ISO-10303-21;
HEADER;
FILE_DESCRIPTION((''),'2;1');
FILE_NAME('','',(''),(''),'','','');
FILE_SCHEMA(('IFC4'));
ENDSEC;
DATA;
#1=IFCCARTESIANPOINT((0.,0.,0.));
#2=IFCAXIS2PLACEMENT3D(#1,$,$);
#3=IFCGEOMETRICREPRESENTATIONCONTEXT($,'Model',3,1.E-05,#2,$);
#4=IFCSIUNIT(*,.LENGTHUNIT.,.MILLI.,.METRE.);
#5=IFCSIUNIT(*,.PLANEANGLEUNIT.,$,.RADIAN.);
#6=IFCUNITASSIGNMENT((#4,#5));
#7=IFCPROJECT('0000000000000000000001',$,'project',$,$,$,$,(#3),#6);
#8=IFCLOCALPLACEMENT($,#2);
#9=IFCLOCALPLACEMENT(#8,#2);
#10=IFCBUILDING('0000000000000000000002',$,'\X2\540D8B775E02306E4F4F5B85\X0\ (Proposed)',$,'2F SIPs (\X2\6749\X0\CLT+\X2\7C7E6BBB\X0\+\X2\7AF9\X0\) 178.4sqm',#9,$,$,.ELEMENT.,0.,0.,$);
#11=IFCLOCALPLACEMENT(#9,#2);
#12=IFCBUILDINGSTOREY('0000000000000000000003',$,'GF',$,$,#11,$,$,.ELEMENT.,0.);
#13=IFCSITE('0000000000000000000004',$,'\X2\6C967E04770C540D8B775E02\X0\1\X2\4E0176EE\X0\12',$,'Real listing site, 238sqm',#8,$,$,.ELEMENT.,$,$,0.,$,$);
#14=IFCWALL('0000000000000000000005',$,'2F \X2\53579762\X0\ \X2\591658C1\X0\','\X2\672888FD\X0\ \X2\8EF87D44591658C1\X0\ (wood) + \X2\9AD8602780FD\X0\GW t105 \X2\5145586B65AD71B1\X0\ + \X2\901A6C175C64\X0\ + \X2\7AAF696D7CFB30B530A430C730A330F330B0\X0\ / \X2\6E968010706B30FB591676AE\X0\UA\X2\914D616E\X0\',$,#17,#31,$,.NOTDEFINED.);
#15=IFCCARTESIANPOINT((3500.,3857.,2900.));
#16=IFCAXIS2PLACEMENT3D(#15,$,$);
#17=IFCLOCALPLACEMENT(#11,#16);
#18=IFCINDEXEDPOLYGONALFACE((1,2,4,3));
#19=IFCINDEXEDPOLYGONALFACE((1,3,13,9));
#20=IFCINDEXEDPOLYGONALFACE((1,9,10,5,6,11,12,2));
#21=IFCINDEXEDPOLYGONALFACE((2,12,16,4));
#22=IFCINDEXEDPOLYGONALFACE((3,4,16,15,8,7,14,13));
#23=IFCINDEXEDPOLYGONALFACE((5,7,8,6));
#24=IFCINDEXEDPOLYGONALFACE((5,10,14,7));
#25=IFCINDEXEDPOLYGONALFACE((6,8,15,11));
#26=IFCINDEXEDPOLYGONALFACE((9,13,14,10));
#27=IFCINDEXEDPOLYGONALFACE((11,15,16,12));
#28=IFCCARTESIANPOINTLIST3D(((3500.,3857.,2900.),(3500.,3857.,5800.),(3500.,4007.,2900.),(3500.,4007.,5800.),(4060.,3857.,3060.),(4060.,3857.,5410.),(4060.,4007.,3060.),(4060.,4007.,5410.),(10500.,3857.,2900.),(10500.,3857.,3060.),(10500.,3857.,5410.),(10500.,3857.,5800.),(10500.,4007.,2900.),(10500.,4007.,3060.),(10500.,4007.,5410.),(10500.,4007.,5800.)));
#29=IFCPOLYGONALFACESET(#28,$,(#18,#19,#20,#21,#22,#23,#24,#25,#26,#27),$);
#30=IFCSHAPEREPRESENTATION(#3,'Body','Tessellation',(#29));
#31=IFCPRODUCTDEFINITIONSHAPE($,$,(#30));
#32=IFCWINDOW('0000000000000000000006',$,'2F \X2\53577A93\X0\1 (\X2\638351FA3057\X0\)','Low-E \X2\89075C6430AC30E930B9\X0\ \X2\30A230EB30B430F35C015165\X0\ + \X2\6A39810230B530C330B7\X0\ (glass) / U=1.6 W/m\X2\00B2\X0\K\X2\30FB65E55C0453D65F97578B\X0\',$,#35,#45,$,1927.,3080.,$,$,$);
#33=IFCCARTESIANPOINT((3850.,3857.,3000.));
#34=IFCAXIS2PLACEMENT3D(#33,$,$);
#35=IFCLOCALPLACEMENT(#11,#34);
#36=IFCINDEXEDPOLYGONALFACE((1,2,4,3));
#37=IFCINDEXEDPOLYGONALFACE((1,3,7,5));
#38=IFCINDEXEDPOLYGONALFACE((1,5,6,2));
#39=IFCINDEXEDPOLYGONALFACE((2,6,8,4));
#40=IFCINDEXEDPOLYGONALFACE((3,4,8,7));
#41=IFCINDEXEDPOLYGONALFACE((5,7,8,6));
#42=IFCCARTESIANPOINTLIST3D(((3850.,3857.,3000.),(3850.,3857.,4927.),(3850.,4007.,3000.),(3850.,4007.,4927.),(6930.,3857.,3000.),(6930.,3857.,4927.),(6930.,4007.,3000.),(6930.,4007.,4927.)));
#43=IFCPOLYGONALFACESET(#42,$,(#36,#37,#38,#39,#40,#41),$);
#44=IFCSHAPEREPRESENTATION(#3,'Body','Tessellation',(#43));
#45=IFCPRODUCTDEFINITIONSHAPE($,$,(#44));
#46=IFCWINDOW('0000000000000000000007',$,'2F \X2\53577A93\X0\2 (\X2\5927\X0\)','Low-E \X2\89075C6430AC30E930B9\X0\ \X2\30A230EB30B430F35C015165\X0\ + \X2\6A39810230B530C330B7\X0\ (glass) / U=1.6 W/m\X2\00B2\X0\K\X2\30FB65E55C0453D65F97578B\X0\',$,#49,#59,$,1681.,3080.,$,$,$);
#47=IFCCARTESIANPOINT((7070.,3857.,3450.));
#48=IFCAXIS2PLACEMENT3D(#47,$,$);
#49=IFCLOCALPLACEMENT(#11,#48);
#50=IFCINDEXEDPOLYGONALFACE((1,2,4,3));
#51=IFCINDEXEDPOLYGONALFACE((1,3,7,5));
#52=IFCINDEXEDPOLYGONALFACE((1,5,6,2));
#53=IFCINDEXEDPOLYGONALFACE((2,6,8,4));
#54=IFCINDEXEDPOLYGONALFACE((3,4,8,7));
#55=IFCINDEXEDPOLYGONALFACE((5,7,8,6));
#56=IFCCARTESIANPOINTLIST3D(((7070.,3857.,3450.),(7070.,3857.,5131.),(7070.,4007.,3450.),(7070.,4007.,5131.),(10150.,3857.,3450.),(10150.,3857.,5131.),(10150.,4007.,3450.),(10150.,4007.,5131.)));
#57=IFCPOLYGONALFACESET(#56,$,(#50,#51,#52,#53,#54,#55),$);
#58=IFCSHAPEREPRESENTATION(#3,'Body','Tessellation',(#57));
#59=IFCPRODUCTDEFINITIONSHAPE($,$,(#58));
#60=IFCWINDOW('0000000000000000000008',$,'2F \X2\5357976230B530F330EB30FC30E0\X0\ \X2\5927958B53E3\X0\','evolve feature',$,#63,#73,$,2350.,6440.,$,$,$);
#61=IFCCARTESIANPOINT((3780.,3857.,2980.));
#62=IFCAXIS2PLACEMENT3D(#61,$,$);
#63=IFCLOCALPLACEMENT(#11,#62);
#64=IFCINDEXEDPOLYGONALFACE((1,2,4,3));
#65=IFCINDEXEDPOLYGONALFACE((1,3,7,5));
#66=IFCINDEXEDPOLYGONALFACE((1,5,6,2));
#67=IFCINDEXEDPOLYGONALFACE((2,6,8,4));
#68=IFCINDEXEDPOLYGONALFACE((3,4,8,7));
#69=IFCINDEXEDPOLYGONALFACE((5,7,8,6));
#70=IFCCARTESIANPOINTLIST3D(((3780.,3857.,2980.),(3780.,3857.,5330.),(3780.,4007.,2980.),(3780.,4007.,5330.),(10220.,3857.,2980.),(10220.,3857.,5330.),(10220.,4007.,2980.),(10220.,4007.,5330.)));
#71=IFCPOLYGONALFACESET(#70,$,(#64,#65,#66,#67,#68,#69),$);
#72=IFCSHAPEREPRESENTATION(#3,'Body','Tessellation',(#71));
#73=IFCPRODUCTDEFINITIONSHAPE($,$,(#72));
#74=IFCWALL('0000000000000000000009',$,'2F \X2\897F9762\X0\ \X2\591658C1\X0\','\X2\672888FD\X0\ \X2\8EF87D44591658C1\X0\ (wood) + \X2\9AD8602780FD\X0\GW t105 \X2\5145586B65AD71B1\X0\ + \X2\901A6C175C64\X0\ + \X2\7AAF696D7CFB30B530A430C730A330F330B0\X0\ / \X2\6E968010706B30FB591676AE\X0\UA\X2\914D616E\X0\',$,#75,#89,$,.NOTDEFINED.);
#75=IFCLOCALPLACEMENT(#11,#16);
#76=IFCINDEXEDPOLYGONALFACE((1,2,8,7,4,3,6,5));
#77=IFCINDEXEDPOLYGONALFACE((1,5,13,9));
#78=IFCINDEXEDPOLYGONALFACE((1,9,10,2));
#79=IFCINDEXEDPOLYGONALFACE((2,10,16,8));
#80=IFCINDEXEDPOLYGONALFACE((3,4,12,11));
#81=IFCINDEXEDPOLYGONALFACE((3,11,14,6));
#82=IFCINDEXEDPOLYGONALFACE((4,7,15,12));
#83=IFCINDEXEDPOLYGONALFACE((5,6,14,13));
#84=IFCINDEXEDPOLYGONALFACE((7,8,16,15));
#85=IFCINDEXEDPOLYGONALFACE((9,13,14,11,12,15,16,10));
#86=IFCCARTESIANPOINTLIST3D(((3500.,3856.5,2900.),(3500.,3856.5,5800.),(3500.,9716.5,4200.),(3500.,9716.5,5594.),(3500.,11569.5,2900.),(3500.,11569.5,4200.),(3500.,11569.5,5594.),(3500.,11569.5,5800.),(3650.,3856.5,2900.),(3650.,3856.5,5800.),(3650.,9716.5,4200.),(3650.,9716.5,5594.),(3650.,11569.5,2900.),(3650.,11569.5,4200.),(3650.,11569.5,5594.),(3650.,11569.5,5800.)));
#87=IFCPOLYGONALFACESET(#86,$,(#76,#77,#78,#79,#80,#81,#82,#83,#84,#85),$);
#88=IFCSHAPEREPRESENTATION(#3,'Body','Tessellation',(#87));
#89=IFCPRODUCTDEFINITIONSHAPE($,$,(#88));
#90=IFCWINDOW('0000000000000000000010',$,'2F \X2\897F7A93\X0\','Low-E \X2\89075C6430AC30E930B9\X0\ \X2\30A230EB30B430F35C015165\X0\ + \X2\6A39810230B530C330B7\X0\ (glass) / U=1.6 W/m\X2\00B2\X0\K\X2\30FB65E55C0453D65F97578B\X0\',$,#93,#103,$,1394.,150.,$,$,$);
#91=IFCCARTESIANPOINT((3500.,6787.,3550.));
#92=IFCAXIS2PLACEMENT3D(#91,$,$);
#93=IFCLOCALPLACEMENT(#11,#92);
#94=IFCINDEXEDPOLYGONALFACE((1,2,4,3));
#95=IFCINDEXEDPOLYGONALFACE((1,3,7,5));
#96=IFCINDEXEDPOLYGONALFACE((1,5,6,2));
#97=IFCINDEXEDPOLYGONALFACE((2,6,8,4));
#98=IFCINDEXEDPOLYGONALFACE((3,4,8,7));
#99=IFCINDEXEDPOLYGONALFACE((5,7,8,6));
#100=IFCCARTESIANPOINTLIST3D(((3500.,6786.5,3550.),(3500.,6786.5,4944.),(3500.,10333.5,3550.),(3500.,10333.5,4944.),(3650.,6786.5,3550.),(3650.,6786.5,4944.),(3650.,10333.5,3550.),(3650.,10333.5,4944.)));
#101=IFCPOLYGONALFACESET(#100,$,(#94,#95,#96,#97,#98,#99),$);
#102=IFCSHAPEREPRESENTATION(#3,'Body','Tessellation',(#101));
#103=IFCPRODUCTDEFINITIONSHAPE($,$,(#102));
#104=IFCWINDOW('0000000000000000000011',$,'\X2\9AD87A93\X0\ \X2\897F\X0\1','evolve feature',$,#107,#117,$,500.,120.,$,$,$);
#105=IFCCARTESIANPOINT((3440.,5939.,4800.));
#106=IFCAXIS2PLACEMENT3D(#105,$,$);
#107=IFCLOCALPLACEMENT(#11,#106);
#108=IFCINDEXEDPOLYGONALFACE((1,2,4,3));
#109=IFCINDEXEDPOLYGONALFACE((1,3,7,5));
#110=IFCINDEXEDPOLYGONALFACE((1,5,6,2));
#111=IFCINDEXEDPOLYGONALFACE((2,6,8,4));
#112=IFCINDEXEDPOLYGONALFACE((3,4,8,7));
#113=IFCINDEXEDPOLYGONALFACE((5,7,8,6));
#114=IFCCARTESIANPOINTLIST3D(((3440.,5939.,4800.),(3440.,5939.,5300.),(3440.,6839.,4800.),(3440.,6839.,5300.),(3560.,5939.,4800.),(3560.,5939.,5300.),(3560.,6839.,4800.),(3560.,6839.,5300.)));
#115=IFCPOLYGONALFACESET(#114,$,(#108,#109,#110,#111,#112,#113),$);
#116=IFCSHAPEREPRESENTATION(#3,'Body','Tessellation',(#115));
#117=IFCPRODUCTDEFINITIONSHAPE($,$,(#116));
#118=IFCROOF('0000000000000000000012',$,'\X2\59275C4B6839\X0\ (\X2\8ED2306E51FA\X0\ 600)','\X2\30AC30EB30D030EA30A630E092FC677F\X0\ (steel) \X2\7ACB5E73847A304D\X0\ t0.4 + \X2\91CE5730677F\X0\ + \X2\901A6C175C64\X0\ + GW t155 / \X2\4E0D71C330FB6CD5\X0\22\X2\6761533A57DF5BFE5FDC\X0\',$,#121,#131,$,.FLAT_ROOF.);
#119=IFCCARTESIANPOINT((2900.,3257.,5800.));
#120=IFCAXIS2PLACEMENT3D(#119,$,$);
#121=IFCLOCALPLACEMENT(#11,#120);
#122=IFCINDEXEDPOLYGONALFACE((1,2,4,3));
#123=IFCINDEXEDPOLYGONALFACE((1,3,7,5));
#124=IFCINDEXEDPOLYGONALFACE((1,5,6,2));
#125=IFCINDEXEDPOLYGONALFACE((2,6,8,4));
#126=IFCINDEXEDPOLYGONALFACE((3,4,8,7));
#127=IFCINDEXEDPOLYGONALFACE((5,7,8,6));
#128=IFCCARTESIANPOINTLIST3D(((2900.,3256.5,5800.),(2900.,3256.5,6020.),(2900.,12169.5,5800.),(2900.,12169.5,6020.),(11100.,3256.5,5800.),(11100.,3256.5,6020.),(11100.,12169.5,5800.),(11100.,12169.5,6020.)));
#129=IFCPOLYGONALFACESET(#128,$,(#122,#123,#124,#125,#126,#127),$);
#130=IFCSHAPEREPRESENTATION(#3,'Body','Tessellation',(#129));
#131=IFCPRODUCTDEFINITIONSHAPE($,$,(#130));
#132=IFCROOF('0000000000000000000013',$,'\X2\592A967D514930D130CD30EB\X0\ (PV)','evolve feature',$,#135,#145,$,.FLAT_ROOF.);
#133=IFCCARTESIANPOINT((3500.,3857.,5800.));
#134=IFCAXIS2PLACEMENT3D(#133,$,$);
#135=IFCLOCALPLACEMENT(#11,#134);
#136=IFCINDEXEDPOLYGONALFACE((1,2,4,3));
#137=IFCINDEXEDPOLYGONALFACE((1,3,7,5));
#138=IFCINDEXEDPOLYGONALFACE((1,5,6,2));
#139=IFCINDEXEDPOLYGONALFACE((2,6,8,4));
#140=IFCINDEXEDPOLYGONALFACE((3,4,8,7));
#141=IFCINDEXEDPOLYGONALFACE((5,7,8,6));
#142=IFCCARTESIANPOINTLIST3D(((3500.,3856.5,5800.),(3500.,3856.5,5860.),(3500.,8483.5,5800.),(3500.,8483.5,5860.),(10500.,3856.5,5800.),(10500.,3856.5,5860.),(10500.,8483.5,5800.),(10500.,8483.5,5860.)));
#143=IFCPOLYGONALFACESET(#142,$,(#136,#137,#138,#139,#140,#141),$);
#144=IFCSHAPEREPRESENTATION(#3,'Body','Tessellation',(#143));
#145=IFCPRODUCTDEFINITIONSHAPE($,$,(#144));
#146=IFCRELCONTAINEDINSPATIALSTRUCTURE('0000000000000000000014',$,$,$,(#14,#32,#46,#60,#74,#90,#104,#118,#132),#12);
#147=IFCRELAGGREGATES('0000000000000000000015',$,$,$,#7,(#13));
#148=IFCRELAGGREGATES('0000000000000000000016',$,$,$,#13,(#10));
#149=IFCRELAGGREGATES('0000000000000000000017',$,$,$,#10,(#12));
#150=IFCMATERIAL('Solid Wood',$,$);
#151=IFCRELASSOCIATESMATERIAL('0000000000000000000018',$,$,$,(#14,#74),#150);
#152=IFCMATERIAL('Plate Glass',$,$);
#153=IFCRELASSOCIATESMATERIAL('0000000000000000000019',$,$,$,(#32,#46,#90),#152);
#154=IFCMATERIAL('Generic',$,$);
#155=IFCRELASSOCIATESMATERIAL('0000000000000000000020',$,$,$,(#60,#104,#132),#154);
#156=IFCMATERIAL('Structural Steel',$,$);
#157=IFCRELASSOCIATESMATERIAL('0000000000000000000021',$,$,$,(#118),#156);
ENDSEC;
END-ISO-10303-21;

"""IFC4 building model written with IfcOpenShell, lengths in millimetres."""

from ifc_helpers import new_model, si_unit, frame, frame_2d, origin, place, context, project, spatial, rectangle, extrude, material, element, fill, save


model = new_model("IFC4")

# Units and contexts
model_context = context("Model", 3, precision=1e-05, world=origin())
ifc_project = project(units=[si_unit("LENGTHUNIT", "METRE", prefix="MILLI"), si_unit("PLANEANGLEUNIT", "RADIAN")], contexts=[model_context])

# Site, building, storey
site_placement = place(None, origin())
site = spatial("IfcSite", under=ifc_project, at=site_placement, Name="沖縄県名護市1丁目12", ObjectType="Real listing site, 238sqm", CompositionType="ELEMENT", RefElevation=0.0)
building_placement = place(site_placement, origin())
building = spatial("IfcBuilding", under=site, at=building_placement, Name="名護市の住宅 (Proposed)", ObjectType="2F SIPs (杉CLT+籾殻+竹) 178.4sqm", CompositionType="ELEMENT", ElevationOfRefHeight=0.0, ElevationOfTerrain=0.0)
storey_placement = place(building_placement, origin())
storey = spatial("IfcBuildingStorey", under=building, at=storey_placement, Name="GF", CompositionType="ELEMENT", Elevation=0.0)

# Shared definitions
ifc_material_1 = material(Name="Solid Wood")
ifc_material_2 = material(Name="Generic")

# Shared definitions
ifc_material_3 = material(Name="Plate Glass")

# Walls, openings, windows
wall_1_placement = place(storey_placement, frame((3500.0, 3857.0, 2900.0)))
wall_1 = element("IfcWall", 1, at=wall_1_placement, inside=storey, material=ifc_material_1, Name="2F 南面 外壁", Description="木製 軸組外壁 (wood) + 高性能GW t105 充填断熱 + 通気層 + 窯業系サイディング / 準耐火・外皮UA配慮", PredefinedType="NOTDEFINED", context=model_context, shape_type="SweptSolid", body=[
    extrude(rectangle(XDim=7000.0, YDim=150.0, at=frame_2d((3500.0, 75.0))), frame((3500.0, 3857.0, 2900.0)), (0.0, 0.0, 1.0), 2900.0),
])
opening_1_placement = place(storey_placement, frame((3850.0, 3857.0, 3000.0)))
opening_1 = element("IfcOpeningElement", 2, at=opening_1_placement, cuts=wall_1, PredefinedType="NOTDEFINED", context=model_context, shape_type="SweptSolid", body=[
    extrude(rectangle(XDim=3080.0, YDim=150.0, at=frame_2d((1540.0, 75.0))), frame((3850.0, 3857.0, 3000.0)), (0.0, 0.0, 1.0), 1927.0),
])
opening_2_placement = place(storey_placement, frame((7070.0, 3857.0, 3450.0)))
opening_2 = element("IfcOpeningElement", 3, at=opening_2_placement, cuts=wall_1, PredefinedType="NOTDEFINED", context=model_context, shape_type="SweptSolid", body=[
    extrude(rectangle(XDim=3080.0, YDim=150.0, at=frame_2d((1540.0, 75.0))), frame((7070.0, 3857.0, 3450.0)), (0.0, 0.0, 1.0), 1681.0),
])
opening_3_placement = place(storey_placement, frame((3780.0, 3857.0, 2980.0)))
opening_3 = element("IfcOpeningElement", 4, at=opening_3_placement, cuts=wall_1, PredefinedType="NOTDEFINED", context=model_context, shape_type="SweptSolid", body=[
    extrude(rectangle(XDim=6440.0, YDim=150.0, at=frame_2d((3220.0, 75.0))), frame((3780.0, 3857.0, 2980.0)), (0.0, 0.0, 1.0), 2350.0),
])
window_1_placement = place(storey_placement, frame((3850.0, 3857.0, 3000.0)))
window_1 = element("IfcWindow", 5, at=window_1_placement, inside=storey, material=ifc_material_3, Name="2F 南窓1 (掃出し)", Description="Low-E 複層ガラス アルゴン封入 + 樹脂サッシ (glass) / U=1.6 W/m²K・日射取得型", OverallHeight=1927.0, OverallWidth=3080.0, context=model_context, shape_type="SweptSolid", body=[
    extrude(rectangle(XDim=3080.0, YDim=150.0, at=frame_2d((1540.0, 75.0))), frame((3850.0, 3857.0, 3000.0)), (0.0, 0.0, 1.0), 1927.0),
])
fill(opening_1, window_1)
window_2_placement = place(storey_placement, frame((7070.0, 3857.0, 3450.0)))
window_2 = element("IfcWindow", 6, at=window_2_placement, inside=storey, material=ifc_material_3, Name="2F 南窓2 (大)", Description="Low-E 複層ガラス アルゴン封入 + 樹脂サッシ (glass) / U=1.6 W/m²K・日射取得型", OverallHeight=1681.0, OverallWidth=3080.0, context=model_context, shape_type="SweptSolid", body=[
    extrude(rectangle(XDim=3080.0, YDim=150.0, at=frame_2d((1540.0, 75.0))), frame((7070.0, 3857.0, 3450.0)), (0.0, 0.0, 1.0), 1681.0),
])
fill(opening_2, window_2)
window_3_placement = place(storey_placement, frame((3780.0, 3857.0, 2980.0)))
window_3 = element("IfcWindow", 7, at=window_3_placement, inside=storey, material=ifc_material_2, Name="2F 南面サンルーム 大開口", Description="evolve feature", OverallHeight=2350.0, OverallWidth=6440.0, context=model_context, shape_type="SweptSolid", body=[
    extrude(rectangle(XDim=6440.0, YDim=150.0, at=frame_2d((3220.0, 75.0))), frame((3780.0, 3857.0, 2980.0)), (0.0, 0.0, 1.0), 2350.0),
])
fill(opening_3, window_3)
wall_2_placement = place(storey_placement, frame((3500.0, 3857.0, 2900.0)))
wall_2 = element("IfcWall", 8, at=wall_2_placement, inside=storey, material=ifc_material_1, Name="2F 西面 外壁", Description="木製 軸組外壁 (wood) + 高性能GW t105 充填断熱 + 通気層 + 窯業系サイディング / 準耐火・外皮UA配慮", PredefinedType="NOTDEFINED", context=model_context, shape_type="SweptSolid", body=[
    extrude(rectangle(XDim=150.0, YDim=7713.0, at=frame_2d((75.0, 3856.0))), frame((3500.0, 3857.0, 2900.0)), (0.0, 0.0, 1.0), 2900.0),
])
opening_4_placement = place(storey_placement, frame((3500.0, 6787.0, 3550.0)))
opening_4 = element("IfcOpeningElement", 9, at=opening_4_placement, cuts=wall_2, PredefinedType="NOTDEFINED", context=model_context, shape_type="SweptSolid", body=[
    extrude(rectangle(XDim=150.0, YDim=3547.0, at=frame_2d((75.0, 1773.0))), frame((3500.0, 6787.0, 3550.0)), (0.0, 0.0, 1.0), 1394.0),
])
opening_5_placement = place(storey_placement, frame((3440.0, 5939.0, 4800.0)))
opening_5 = element("IfcOpeningElement", 10, at=opening_5_placement, cuts=wall_2, PredefinedType="NOTDEFINED", context=model_context, shape_type="SweptSolid", body=[
    extrude(rectangle(XDim=120.0, YDim=900.0, at=frame_2d((60.0, 450.0))), frame((3440.0, 5939.0, 4800.0)), (0.0, 0.0, 1.0), 500.0),
])
window_4_placement = place(storey_placement, frame((3500.0, 6787.0, 3550.0)))
window_4 = element("IfcWindow", 11, at=window_4_placement, inside=storey, material=ifc_material_3, Name="2F 西窓", Description="Low-E 複層ガラス アルゴン封入 + 樹脂サッシ (glass) / U=1.6 W/m²K・日射取得型", OverallHeight=1394.0, OverallWidth=150.0, context=model_context, shape_type="SweptSolid", body=[
    extrude(rectangle(XDim=150.0, YDim=3547.0, at=frame_2d((75.0, 1773.0))), frame((3500.0, 6787.0, 3550.0)), (0.0, 0.0, 1.0), 1394.0),
])
fill(opening_4, window_4)
window_5_placement = place(storey_placement, frame((3440.0, 5939.0, 4800.0)))
window_5 = element("IfcWindow", 12, at=window_5_placement, inside=storey, material=ifc_material_2, Name="高窓 西1", Description="evolve feature", OverallHeight=500.0, OverallWidth=120.0, context=model_context, shape_type="SweptSolid", body=[
    extrude(rectangle(XDim=120.0, YDim=900.0, at=frame_2d((60.0, 450.0))), frame((3440.0, 5939.0, 4800.0)), (0.0, 0.0, 1.0), 500.0),
])
fill(opening_5, window_5)

# Roofs
ifc_material_4 = material(Name="Structural Steel")
roof_1_placement = place(storey_placement, frame((2900.0, 3257.0, 5800.0)))
element("IfcRoof", 13, at=roof_1_placement, inside=storey, material=ifc_material_4, Name="大屋根 (軒の出 600)", Description="ガルバリウム鋼板 (steel) 立平葺き t0.4 + 野地板 + 通気層 + GW t155 / 不燃・法22条区域対応", PredefinedType="FLAT_ROOF", context=model_context, shape_type="SweptSolid", body=[
    extrude(rectangle(XDim=8200.0, YDim=8913.0, at=frame_2d((4100.0, 4456.0))), frame((2900.0, 3257.0, 5800.0)), (0.0, 0.0, 1.0), 220.0),
])
roof_2_placement = place(storey_placement, frame((3500.0, 3857.0, 5800.0)))
element("IfcRoof", 14, at=roof_2_placement, inside=storey, material=ifc_material_2, Name="太陽光パネル (PV)", Description="evolve feature", PredefinedType="FLAT_ROOF", context=model_context, shape_type="SweptSolid", body=[
    extrude(rectangle(XDim=7000.0, YDim=4627.0, at=frame_2d((3500.0, 2313.0))), frame((3500.0, 3857.0, 5800.0)), (0.0, 0.0, 1.0), 60.0),
])

save(model, "model.ifc")
